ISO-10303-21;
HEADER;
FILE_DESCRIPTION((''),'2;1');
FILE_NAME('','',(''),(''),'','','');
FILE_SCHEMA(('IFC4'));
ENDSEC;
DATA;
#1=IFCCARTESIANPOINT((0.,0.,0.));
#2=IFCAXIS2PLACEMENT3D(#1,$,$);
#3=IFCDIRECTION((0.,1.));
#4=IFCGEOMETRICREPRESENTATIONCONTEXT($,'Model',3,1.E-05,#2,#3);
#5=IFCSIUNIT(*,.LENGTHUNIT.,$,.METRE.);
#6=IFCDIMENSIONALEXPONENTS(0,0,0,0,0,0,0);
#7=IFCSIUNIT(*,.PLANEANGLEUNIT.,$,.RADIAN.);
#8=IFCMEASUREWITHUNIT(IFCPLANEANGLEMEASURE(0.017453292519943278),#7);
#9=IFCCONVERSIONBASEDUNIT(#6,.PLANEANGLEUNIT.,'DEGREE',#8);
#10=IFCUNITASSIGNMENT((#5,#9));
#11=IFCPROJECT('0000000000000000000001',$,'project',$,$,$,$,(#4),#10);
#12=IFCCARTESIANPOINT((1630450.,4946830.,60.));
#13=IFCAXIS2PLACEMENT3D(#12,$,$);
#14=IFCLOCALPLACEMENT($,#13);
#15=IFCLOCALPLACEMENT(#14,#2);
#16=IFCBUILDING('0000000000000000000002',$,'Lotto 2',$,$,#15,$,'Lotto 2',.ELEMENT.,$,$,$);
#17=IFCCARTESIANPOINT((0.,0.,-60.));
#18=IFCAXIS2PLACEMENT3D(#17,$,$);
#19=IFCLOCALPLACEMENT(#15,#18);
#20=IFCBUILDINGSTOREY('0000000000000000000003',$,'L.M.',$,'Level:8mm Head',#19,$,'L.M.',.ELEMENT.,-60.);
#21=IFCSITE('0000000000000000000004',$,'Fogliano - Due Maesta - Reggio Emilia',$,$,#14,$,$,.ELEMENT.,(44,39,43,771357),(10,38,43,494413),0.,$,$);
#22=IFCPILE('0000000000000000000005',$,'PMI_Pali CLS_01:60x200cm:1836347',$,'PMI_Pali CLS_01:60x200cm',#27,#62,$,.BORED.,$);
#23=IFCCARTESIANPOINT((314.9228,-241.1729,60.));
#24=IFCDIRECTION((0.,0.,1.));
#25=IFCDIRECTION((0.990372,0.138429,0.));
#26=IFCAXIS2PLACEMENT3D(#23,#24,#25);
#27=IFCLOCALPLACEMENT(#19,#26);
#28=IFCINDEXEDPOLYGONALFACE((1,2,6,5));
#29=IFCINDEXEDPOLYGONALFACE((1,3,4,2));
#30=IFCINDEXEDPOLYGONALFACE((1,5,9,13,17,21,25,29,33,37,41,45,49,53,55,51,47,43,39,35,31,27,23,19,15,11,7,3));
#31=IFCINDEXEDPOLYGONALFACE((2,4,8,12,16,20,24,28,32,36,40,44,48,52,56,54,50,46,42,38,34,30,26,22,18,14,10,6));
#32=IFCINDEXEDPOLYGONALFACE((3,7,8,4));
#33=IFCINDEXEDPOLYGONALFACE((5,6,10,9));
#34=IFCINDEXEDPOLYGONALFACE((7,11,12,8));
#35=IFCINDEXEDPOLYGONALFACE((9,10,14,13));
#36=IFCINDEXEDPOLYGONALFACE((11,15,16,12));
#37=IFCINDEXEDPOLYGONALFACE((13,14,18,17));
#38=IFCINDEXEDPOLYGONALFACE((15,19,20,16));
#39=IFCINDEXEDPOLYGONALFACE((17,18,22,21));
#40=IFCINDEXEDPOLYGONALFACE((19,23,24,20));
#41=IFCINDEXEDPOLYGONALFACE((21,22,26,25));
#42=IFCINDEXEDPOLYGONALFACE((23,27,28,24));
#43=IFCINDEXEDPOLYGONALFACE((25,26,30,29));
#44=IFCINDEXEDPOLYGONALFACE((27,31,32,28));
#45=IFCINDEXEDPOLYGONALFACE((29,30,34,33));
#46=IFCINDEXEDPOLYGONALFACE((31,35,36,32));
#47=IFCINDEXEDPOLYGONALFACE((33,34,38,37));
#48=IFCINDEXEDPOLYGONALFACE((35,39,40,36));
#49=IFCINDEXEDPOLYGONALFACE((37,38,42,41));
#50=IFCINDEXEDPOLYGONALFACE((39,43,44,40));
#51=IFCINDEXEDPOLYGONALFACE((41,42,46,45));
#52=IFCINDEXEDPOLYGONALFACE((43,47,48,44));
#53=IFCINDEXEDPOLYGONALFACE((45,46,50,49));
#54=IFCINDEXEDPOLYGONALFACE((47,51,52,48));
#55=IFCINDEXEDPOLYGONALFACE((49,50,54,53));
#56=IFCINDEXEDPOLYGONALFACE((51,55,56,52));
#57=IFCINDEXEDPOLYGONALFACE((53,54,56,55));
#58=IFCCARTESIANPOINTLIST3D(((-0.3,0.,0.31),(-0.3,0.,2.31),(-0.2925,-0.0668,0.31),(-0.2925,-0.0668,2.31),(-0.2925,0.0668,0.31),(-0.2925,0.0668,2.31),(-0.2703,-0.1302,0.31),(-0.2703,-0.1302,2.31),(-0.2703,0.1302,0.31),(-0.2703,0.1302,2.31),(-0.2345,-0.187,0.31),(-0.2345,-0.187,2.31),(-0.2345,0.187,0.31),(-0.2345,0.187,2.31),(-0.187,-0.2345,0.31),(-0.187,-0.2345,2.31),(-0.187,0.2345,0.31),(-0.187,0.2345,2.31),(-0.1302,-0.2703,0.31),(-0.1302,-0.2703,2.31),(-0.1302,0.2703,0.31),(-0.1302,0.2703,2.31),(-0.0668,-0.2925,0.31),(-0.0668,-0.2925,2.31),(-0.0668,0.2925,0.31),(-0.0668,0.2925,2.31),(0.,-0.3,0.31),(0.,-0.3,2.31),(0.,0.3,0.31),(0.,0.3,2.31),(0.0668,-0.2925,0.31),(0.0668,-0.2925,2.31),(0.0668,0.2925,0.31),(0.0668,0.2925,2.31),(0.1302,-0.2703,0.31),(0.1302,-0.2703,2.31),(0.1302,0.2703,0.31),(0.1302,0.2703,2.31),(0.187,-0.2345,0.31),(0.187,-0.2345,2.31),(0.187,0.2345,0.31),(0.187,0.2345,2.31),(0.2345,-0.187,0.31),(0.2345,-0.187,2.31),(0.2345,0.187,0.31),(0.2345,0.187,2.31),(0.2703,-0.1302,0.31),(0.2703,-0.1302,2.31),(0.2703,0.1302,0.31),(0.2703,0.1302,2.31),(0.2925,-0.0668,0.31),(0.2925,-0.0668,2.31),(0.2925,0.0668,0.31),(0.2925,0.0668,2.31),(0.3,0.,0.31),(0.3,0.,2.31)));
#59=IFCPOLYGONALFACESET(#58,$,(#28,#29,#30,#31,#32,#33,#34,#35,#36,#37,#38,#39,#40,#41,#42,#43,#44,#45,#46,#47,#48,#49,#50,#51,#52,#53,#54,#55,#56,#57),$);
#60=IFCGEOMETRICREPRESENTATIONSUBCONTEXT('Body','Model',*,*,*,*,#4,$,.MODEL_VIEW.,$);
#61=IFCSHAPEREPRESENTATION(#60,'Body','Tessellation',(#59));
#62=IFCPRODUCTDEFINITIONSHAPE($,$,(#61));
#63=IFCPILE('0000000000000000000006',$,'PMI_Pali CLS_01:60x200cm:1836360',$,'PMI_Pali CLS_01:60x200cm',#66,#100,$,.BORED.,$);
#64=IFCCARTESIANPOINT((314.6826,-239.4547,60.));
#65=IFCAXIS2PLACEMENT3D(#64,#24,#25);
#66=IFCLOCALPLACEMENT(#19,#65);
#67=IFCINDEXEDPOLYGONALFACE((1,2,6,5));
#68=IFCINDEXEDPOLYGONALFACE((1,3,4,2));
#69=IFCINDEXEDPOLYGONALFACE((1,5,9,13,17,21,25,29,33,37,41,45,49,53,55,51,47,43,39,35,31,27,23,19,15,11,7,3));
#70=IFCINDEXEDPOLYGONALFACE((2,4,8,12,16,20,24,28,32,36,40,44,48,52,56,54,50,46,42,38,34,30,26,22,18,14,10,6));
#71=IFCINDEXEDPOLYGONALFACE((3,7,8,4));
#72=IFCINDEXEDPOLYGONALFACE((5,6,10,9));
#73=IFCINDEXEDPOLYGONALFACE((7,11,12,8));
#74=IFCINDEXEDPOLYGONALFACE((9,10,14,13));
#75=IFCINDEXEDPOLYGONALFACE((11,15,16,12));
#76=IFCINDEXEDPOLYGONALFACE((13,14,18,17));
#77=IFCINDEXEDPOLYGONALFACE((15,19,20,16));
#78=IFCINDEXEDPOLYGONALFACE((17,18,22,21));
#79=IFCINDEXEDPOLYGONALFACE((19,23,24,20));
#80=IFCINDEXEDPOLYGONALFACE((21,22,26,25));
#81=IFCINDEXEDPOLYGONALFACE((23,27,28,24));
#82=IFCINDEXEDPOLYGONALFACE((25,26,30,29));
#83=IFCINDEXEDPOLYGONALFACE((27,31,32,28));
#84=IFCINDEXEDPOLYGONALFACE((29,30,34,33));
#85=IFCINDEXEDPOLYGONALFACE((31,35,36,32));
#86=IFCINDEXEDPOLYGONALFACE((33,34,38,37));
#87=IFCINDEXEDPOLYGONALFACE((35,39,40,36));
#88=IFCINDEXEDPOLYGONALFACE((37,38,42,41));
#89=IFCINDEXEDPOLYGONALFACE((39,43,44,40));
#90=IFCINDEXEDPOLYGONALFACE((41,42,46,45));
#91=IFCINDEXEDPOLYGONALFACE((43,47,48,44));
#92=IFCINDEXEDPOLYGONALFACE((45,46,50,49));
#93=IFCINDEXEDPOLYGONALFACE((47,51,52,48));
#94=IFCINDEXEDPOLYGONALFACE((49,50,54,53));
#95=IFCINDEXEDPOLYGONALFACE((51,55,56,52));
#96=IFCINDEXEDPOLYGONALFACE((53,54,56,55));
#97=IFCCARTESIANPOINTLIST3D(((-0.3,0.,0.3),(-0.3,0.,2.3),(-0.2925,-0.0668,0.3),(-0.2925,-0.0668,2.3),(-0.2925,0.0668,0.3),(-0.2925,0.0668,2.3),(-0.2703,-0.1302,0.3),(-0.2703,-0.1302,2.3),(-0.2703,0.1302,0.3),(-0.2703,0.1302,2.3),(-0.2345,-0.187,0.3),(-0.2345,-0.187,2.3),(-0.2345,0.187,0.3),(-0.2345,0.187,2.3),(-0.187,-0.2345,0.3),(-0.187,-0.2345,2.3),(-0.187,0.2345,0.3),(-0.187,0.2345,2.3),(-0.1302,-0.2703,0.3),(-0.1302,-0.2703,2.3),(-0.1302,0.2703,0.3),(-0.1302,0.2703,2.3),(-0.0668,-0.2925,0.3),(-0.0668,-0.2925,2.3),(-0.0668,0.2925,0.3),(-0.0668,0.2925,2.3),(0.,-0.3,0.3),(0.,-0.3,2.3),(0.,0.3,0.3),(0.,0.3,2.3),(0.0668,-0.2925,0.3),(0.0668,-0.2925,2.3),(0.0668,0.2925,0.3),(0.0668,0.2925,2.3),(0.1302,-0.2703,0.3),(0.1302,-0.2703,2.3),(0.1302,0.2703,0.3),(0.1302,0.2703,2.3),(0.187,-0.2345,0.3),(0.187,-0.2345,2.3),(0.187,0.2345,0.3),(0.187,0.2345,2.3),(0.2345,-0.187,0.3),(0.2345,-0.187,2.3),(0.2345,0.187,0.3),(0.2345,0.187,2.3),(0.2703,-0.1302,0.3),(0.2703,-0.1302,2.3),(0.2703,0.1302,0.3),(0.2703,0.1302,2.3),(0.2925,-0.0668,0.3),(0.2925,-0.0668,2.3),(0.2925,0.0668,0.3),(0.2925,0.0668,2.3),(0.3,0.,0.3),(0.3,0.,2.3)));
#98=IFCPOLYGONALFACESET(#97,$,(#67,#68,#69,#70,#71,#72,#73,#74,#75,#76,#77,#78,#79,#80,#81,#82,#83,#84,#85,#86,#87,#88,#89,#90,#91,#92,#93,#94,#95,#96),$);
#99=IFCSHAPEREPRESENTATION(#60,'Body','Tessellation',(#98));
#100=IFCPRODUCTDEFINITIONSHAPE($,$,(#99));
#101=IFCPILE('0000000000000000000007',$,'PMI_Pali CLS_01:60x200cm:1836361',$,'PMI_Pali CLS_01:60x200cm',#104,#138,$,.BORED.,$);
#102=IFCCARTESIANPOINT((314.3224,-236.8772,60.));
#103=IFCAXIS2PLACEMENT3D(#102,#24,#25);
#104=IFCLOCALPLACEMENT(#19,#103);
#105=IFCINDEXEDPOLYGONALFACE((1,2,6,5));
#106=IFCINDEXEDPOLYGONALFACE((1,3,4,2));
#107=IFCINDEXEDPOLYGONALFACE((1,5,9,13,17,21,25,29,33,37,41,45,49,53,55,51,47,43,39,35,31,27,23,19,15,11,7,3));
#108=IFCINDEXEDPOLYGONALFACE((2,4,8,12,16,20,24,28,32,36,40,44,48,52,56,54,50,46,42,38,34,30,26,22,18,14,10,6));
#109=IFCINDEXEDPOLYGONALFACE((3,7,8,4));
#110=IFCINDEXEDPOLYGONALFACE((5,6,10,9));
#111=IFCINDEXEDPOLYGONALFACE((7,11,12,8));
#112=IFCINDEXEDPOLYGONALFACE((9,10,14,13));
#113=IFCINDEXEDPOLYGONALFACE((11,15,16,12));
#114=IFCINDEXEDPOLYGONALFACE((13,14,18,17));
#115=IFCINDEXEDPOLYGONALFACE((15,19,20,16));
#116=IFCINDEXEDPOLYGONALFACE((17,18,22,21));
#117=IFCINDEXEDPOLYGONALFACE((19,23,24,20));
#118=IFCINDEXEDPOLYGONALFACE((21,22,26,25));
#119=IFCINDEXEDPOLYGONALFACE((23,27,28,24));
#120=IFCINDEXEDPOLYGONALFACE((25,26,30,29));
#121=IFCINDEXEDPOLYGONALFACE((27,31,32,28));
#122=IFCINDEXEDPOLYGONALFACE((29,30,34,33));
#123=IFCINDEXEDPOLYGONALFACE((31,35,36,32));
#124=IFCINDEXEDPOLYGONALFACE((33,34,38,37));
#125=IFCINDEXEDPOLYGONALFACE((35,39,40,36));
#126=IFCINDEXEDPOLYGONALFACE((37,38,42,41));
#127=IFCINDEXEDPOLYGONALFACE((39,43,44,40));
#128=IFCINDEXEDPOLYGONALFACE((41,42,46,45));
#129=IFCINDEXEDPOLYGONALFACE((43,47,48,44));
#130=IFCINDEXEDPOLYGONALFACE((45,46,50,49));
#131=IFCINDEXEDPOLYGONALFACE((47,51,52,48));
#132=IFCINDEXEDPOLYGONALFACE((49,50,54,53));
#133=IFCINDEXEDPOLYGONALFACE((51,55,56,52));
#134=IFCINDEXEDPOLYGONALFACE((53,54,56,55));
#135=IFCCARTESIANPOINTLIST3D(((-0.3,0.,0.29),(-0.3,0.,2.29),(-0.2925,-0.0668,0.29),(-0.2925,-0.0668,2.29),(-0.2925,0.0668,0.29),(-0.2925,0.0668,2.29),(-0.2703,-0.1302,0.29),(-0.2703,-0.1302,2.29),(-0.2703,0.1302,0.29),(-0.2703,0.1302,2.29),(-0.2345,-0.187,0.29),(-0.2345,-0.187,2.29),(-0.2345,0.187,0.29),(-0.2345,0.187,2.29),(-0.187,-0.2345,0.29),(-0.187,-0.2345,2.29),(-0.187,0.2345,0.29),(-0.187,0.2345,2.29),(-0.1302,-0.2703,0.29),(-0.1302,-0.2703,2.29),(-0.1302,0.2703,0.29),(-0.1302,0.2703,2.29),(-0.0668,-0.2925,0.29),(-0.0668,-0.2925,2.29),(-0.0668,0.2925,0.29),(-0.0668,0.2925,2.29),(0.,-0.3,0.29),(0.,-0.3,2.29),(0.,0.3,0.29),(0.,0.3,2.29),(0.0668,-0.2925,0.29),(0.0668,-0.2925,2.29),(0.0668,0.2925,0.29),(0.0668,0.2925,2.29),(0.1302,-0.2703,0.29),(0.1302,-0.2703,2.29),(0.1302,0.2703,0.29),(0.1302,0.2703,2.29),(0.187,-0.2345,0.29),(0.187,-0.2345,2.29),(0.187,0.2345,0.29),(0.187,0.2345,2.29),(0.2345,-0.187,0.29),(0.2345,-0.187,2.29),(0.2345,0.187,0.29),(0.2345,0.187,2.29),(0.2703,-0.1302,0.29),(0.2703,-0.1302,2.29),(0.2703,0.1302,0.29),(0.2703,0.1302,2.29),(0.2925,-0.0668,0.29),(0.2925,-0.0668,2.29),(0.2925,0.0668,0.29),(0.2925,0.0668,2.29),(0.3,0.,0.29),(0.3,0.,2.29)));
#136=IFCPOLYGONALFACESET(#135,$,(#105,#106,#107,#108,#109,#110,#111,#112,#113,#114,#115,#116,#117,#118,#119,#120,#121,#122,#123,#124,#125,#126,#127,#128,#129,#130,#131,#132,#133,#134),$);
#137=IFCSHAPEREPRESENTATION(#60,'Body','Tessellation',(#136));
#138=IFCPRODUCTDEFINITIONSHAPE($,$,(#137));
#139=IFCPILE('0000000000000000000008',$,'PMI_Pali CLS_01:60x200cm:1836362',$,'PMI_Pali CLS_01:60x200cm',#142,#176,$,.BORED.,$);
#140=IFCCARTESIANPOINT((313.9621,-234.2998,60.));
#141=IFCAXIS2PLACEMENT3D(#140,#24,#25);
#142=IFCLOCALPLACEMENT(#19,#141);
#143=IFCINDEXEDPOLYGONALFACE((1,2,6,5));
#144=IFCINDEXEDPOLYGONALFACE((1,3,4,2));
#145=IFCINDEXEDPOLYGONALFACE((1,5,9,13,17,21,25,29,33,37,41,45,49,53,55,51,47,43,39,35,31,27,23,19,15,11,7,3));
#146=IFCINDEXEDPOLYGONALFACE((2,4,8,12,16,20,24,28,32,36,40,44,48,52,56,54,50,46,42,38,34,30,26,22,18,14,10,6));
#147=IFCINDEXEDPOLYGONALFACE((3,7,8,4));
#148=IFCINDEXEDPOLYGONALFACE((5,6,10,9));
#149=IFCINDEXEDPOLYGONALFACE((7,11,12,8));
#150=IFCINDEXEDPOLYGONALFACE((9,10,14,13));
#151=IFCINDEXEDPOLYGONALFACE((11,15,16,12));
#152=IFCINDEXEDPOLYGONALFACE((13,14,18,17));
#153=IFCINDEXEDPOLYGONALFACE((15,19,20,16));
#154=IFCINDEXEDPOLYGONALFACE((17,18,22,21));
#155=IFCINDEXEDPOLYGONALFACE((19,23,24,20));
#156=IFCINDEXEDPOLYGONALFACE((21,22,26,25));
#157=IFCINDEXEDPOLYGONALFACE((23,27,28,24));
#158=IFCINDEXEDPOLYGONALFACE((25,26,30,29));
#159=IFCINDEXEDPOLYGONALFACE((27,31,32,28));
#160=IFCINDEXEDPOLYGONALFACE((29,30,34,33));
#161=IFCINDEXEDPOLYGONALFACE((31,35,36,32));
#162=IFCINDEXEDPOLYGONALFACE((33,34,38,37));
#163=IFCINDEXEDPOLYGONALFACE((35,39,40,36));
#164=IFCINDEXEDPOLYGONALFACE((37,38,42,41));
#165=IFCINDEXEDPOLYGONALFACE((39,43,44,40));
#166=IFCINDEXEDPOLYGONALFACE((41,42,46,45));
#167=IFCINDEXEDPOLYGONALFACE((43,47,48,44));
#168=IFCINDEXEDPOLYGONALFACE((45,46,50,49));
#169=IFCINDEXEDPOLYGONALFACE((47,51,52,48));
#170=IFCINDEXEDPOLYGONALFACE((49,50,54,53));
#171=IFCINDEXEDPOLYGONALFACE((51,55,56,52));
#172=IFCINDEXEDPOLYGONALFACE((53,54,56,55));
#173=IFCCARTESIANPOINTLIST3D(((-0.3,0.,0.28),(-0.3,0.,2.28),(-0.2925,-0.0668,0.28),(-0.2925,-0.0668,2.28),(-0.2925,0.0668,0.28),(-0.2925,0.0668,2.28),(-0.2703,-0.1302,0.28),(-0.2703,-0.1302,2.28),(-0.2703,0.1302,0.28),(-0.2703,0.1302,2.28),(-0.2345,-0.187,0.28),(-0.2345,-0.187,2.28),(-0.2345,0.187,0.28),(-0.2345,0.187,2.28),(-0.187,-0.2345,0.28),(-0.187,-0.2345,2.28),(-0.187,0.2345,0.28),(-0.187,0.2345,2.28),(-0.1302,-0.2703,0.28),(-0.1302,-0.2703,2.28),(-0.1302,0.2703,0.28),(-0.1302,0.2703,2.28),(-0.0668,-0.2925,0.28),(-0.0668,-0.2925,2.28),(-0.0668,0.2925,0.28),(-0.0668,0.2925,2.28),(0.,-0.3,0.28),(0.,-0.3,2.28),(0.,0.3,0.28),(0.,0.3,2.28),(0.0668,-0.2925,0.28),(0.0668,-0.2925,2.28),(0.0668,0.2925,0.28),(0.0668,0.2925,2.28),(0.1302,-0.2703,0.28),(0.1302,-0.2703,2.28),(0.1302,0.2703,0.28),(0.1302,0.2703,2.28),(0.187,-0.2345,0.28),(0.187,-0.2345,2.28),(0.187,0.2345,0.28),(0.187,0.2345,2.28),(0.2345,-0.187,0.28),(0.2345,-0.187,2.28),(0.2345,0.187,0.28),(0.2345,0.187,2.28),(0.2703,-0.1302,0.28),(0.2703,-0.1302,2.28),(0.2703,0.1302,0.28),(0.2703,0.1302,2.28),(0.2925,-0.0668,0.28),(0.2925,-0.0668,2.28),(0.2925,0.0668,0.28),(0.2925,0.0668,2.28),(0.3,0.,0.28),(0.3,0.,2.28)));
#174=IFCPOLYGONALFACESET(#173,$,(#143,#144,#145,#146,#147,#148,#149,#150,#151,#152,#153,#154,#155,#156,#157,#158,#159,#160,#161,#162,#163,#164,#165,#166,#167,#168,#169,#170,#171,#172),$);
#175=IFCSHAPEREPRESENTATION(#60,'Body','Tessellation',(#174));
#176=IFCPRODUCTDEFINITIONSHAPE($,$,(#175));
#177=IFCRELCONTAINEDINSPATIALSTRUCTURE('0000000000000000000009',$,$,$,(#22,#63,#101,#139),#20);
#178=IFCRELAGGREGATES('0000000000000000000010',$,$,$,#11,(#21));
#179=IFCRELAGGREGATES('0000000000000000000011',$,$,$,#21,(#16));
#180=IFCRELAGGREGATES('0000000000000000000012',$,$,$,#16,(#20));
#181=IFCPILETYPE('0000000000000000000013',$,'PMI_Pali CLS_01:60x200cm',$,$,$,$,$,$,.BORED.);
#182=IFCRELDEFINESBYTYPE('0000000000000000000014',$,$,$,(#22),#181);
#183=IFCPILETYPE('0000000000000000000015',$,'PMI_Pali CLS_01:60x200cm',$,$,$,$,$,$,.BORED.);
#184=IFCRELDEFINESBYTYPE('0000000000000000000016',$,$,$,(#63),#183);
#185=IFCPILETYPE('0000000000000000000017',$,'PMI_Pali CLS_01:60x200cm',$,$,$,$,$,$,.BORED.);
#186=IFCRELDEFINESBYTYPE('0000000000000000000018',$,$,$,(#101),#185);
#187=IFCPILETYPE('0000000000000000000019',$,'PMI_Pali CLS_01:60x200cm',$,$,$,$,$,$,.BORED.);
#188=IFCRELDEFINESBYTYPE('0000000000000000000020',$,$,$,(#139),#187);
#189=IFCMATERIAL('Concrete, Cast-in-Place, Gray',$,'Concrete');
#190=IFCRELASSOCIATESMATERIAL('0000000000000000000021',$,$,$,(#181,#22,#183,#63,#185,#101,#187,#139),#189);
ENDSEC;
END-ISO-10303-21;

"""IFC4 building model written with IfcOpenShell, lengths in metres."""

from ifc_helpers import new_model, entity, si_unit, converted_unit, direction, frame, origin, place, context, subcontext, project, spatial, arc, indexed_curve, outline, extrude, source, transform, mapped, material, type_object, type_shapes, element, save


model = new_model("IFC4")

# Units and contexts
model_context = context("Model", 3, precision=1e-05, world=origin(), true_north=direction((0.0, 1.0)))
body_context = subcontext(model_context, "Body", "Model", "MODEL_VIEW")
ifc_project = project(units=[si_unit("LENGTHUNIT", "METRE"), converted_unit("PLANEANGLEUNIT", "DEGREE", entity("IfcPlaneAngleMeasure", 0.017453292519943278), si_unit("PLANEANGLEUNIT", "RADIAN"), dimensions=[0, 0, 0, 0, 0, 0, 0])], contexts=[model_context])

# Site, building, storey
site_placement = place(None, frame((1630450.0, 4946830.0, 60.0)))
site = spatial("IfcSite", under=ifc_project, at=site_placement, Name="Fogliano - Due Maesta - Reggio Emilia", CompositionType="ELEMENT", RefLatitude=(44, 39, 43, 771357), RefLongitude=(10, 38, 43, 494413), RefElevation=0.0)
building_placement = place(site_placement, origin())
building = spatial("IfcBuilding", under=site, at=building_placement, Name="Lotto 2", LongName="Lotto 2", CompositionType="ELEMENT")
storey_placement = place(building_placement, frame((0.0, 0.0, -60.0)))
storey = spatial("IfcBuildingStorey", under=building, at=storey_placement, Name="L.M.", ObjectType="Level:8mm Head", LongName="L.M.", CompositionType="ELEMENT", Elevation=-60.0)

# Piles
ifc_material_1 = material(Name="Concrete, Cast-in-Place, Gray", Category="Concrete")
pile_type_1 = type_object("IfcPileType", Name="PMI_Pali CLS_01:60x200cm", PredefinedType="BORED", material=ifc_material_1)
shared_shape_1 = source(origin(), body_context, "Body", "SweptSolid", [
    extrude(outline(indexed_curve([(-0.3, 0.0), (0.0, -0.3), (0.3, 0.0), (0.0, 0.3)], segments=[arc(1, 2, 3), arc(3, 4, 1)], self_intersect=False)), frame((0.0, 0.0, 0.31)), (0.0, 0.0, 1.0), 2.0),
])
type_shapes(pile_type_1, [shared_shape_1])
pile_1_placement = place(storey_placement, frame((314.9228, -241.1729, 60.0), z_axis=(0.0, 0.0, 1.0), x_axis=(0.990372, 0.138429, 0.0)))
element("IfcPile", 1, at=pile_1_placement, inside=storey, type_object=pile_type_1, material=ifc_material_1, Name="PMI_Pali CLS_01:60x200cm:1836347", ObjectType="PMI_Pali CLS_01:60x200cm", PredefinedType="BORED", context=body_context, shape_type="MappedRepresentation", body=[
    mapped(shared_shape_1, transform((0.0, 0.0, 0.0), scale=1.0)),
])
pile_type_2 = type_object("IfcPileType", Name="PMI_Pali CLS_01:60x200cm", PredefinedType="BORED", material=ifc_material_1)
shared_shape_2 = source(origin(), body_context, "Body", "SweptSolid", [
    extrude(outline(indexed_curve([(-0.3, 0.0), (0.0, -0.3), (0.3, 0.0), (0.0, 0.3)], segments=[arc(1, 2, 3), arc(3, 4, 1)], self_intersect=False)), frame((0.0, 0.0, 0.3)), (0.0, 0.0, 1.0), 2.0),
])
type_shapes(pile_type_2, [shared_shape_2])
pile_2_placement = place(storey_placement, frame((314.6826, -239.4547, 60.0), z_axis=(0.0, 0.0, 1.0), x_axis=(0.990372, 0.138429, 0.0)))
element("IfcPile", 2, at=pile_2_placement, inside=storey, type_object=pile_type_2, material=ifc_material_1, Name="PMI_Pali CLS_01:60x200cm:1836360", ObjectType="PMI_Pali CLS_01:60x200cm", PredefinedType="BORED", context=body_context, shape_type="MappedRepresentation", body=[
    mapped(shared_shape_2, transform((0.0, 0.0, 0.0), scale=1.0)),
])
pile_type_3 = type_object("IfcPileType", Name="PMI_Pali CLS_01:60x200cm", PredefinedType="BORED", material=ifc_material_1)
shared_shape_3 = source(origin(), body_context, "Body", "SweptSolid", [
    extrude(outline(indexed_curve([(-0.3, 0.0), (0.0, -0.3), (0.3, 0.0), (0.0, 0.3)], segments=[arc(1, 2, 3), arc(3, 4, 1)], self_intersect=False)), frame((0.0, 0.0, 0.29)), (0.0, 0.0, 1.0), 2.0),
])
type_shapes(pile_type_3, [shared_shape_3])
pile_3_placement = place(storey_placement, frame((314.3224, -236.8772, 60.0), z_axis=(0.0, 0.0, 1.0), x_axis=(0.990372, 0.138429, 0.0)))
element("IfcPile", 3, at=pile_3_placement, inside=storey, type_object=pile_type_3, material=ifc_material_1, Name="PMI_Pali CLS_01:60x200cm:1836361", ObjectType="PMI_Pali CLS_01:60x200cm", PredefinedType="BORED", context=body_context, shape_type="MappedRepresentation", body=[
    mapped(shared_shape_3, transform((0.0, 0.0, 0.0), scale=1.0)),
])
pile_type_4 = type_object("IfcPileType", Name="PMI_Pali CLS_01:60x200cm", PredefinedType="BORED", material=ifc_material_1)
shared_shape_4 = source(origin(), body_context, "Body", "SweptSolid", [
    extrude(outline(indexed_curve([(-0.3, 0.0), (0.0, -0.3), (0.3, 0.0), (0.0, 0.3)], segments=[arc(1, 2, 3), arc(3, 4, 1)], self_intersect=False)), frame((0.0, 0.0, 0.28)), (0.0, 0.0, 1.0), 2.0),
])
type_shapes(pile_type_4, [shared_shape_4])
pile_4_placement = place(storey_placement, frame((313.9621, -234.2998, 60.0), z_axis=(0.0, 0.0, 1.0), x_axis=(0.990372, 0.138429, 0.0)))
element("IfcPile", 4, at=pile_4_placement, inside=storey, type_object=pile_type_4, material=ifc_material_1, Name="PMI_Pali CLS_01:60x200cm:1836362", ObjectType="PMI_Pali CLS_01:60x200cm", PredefinedType="BORED", context=body_context, shape_type="MappedRepresentation", body=[
    mapped(shared_shape_4, transform((0.0, 0.0, 0.0), scale=1.0)),
])

save(model, "model.ifc")
